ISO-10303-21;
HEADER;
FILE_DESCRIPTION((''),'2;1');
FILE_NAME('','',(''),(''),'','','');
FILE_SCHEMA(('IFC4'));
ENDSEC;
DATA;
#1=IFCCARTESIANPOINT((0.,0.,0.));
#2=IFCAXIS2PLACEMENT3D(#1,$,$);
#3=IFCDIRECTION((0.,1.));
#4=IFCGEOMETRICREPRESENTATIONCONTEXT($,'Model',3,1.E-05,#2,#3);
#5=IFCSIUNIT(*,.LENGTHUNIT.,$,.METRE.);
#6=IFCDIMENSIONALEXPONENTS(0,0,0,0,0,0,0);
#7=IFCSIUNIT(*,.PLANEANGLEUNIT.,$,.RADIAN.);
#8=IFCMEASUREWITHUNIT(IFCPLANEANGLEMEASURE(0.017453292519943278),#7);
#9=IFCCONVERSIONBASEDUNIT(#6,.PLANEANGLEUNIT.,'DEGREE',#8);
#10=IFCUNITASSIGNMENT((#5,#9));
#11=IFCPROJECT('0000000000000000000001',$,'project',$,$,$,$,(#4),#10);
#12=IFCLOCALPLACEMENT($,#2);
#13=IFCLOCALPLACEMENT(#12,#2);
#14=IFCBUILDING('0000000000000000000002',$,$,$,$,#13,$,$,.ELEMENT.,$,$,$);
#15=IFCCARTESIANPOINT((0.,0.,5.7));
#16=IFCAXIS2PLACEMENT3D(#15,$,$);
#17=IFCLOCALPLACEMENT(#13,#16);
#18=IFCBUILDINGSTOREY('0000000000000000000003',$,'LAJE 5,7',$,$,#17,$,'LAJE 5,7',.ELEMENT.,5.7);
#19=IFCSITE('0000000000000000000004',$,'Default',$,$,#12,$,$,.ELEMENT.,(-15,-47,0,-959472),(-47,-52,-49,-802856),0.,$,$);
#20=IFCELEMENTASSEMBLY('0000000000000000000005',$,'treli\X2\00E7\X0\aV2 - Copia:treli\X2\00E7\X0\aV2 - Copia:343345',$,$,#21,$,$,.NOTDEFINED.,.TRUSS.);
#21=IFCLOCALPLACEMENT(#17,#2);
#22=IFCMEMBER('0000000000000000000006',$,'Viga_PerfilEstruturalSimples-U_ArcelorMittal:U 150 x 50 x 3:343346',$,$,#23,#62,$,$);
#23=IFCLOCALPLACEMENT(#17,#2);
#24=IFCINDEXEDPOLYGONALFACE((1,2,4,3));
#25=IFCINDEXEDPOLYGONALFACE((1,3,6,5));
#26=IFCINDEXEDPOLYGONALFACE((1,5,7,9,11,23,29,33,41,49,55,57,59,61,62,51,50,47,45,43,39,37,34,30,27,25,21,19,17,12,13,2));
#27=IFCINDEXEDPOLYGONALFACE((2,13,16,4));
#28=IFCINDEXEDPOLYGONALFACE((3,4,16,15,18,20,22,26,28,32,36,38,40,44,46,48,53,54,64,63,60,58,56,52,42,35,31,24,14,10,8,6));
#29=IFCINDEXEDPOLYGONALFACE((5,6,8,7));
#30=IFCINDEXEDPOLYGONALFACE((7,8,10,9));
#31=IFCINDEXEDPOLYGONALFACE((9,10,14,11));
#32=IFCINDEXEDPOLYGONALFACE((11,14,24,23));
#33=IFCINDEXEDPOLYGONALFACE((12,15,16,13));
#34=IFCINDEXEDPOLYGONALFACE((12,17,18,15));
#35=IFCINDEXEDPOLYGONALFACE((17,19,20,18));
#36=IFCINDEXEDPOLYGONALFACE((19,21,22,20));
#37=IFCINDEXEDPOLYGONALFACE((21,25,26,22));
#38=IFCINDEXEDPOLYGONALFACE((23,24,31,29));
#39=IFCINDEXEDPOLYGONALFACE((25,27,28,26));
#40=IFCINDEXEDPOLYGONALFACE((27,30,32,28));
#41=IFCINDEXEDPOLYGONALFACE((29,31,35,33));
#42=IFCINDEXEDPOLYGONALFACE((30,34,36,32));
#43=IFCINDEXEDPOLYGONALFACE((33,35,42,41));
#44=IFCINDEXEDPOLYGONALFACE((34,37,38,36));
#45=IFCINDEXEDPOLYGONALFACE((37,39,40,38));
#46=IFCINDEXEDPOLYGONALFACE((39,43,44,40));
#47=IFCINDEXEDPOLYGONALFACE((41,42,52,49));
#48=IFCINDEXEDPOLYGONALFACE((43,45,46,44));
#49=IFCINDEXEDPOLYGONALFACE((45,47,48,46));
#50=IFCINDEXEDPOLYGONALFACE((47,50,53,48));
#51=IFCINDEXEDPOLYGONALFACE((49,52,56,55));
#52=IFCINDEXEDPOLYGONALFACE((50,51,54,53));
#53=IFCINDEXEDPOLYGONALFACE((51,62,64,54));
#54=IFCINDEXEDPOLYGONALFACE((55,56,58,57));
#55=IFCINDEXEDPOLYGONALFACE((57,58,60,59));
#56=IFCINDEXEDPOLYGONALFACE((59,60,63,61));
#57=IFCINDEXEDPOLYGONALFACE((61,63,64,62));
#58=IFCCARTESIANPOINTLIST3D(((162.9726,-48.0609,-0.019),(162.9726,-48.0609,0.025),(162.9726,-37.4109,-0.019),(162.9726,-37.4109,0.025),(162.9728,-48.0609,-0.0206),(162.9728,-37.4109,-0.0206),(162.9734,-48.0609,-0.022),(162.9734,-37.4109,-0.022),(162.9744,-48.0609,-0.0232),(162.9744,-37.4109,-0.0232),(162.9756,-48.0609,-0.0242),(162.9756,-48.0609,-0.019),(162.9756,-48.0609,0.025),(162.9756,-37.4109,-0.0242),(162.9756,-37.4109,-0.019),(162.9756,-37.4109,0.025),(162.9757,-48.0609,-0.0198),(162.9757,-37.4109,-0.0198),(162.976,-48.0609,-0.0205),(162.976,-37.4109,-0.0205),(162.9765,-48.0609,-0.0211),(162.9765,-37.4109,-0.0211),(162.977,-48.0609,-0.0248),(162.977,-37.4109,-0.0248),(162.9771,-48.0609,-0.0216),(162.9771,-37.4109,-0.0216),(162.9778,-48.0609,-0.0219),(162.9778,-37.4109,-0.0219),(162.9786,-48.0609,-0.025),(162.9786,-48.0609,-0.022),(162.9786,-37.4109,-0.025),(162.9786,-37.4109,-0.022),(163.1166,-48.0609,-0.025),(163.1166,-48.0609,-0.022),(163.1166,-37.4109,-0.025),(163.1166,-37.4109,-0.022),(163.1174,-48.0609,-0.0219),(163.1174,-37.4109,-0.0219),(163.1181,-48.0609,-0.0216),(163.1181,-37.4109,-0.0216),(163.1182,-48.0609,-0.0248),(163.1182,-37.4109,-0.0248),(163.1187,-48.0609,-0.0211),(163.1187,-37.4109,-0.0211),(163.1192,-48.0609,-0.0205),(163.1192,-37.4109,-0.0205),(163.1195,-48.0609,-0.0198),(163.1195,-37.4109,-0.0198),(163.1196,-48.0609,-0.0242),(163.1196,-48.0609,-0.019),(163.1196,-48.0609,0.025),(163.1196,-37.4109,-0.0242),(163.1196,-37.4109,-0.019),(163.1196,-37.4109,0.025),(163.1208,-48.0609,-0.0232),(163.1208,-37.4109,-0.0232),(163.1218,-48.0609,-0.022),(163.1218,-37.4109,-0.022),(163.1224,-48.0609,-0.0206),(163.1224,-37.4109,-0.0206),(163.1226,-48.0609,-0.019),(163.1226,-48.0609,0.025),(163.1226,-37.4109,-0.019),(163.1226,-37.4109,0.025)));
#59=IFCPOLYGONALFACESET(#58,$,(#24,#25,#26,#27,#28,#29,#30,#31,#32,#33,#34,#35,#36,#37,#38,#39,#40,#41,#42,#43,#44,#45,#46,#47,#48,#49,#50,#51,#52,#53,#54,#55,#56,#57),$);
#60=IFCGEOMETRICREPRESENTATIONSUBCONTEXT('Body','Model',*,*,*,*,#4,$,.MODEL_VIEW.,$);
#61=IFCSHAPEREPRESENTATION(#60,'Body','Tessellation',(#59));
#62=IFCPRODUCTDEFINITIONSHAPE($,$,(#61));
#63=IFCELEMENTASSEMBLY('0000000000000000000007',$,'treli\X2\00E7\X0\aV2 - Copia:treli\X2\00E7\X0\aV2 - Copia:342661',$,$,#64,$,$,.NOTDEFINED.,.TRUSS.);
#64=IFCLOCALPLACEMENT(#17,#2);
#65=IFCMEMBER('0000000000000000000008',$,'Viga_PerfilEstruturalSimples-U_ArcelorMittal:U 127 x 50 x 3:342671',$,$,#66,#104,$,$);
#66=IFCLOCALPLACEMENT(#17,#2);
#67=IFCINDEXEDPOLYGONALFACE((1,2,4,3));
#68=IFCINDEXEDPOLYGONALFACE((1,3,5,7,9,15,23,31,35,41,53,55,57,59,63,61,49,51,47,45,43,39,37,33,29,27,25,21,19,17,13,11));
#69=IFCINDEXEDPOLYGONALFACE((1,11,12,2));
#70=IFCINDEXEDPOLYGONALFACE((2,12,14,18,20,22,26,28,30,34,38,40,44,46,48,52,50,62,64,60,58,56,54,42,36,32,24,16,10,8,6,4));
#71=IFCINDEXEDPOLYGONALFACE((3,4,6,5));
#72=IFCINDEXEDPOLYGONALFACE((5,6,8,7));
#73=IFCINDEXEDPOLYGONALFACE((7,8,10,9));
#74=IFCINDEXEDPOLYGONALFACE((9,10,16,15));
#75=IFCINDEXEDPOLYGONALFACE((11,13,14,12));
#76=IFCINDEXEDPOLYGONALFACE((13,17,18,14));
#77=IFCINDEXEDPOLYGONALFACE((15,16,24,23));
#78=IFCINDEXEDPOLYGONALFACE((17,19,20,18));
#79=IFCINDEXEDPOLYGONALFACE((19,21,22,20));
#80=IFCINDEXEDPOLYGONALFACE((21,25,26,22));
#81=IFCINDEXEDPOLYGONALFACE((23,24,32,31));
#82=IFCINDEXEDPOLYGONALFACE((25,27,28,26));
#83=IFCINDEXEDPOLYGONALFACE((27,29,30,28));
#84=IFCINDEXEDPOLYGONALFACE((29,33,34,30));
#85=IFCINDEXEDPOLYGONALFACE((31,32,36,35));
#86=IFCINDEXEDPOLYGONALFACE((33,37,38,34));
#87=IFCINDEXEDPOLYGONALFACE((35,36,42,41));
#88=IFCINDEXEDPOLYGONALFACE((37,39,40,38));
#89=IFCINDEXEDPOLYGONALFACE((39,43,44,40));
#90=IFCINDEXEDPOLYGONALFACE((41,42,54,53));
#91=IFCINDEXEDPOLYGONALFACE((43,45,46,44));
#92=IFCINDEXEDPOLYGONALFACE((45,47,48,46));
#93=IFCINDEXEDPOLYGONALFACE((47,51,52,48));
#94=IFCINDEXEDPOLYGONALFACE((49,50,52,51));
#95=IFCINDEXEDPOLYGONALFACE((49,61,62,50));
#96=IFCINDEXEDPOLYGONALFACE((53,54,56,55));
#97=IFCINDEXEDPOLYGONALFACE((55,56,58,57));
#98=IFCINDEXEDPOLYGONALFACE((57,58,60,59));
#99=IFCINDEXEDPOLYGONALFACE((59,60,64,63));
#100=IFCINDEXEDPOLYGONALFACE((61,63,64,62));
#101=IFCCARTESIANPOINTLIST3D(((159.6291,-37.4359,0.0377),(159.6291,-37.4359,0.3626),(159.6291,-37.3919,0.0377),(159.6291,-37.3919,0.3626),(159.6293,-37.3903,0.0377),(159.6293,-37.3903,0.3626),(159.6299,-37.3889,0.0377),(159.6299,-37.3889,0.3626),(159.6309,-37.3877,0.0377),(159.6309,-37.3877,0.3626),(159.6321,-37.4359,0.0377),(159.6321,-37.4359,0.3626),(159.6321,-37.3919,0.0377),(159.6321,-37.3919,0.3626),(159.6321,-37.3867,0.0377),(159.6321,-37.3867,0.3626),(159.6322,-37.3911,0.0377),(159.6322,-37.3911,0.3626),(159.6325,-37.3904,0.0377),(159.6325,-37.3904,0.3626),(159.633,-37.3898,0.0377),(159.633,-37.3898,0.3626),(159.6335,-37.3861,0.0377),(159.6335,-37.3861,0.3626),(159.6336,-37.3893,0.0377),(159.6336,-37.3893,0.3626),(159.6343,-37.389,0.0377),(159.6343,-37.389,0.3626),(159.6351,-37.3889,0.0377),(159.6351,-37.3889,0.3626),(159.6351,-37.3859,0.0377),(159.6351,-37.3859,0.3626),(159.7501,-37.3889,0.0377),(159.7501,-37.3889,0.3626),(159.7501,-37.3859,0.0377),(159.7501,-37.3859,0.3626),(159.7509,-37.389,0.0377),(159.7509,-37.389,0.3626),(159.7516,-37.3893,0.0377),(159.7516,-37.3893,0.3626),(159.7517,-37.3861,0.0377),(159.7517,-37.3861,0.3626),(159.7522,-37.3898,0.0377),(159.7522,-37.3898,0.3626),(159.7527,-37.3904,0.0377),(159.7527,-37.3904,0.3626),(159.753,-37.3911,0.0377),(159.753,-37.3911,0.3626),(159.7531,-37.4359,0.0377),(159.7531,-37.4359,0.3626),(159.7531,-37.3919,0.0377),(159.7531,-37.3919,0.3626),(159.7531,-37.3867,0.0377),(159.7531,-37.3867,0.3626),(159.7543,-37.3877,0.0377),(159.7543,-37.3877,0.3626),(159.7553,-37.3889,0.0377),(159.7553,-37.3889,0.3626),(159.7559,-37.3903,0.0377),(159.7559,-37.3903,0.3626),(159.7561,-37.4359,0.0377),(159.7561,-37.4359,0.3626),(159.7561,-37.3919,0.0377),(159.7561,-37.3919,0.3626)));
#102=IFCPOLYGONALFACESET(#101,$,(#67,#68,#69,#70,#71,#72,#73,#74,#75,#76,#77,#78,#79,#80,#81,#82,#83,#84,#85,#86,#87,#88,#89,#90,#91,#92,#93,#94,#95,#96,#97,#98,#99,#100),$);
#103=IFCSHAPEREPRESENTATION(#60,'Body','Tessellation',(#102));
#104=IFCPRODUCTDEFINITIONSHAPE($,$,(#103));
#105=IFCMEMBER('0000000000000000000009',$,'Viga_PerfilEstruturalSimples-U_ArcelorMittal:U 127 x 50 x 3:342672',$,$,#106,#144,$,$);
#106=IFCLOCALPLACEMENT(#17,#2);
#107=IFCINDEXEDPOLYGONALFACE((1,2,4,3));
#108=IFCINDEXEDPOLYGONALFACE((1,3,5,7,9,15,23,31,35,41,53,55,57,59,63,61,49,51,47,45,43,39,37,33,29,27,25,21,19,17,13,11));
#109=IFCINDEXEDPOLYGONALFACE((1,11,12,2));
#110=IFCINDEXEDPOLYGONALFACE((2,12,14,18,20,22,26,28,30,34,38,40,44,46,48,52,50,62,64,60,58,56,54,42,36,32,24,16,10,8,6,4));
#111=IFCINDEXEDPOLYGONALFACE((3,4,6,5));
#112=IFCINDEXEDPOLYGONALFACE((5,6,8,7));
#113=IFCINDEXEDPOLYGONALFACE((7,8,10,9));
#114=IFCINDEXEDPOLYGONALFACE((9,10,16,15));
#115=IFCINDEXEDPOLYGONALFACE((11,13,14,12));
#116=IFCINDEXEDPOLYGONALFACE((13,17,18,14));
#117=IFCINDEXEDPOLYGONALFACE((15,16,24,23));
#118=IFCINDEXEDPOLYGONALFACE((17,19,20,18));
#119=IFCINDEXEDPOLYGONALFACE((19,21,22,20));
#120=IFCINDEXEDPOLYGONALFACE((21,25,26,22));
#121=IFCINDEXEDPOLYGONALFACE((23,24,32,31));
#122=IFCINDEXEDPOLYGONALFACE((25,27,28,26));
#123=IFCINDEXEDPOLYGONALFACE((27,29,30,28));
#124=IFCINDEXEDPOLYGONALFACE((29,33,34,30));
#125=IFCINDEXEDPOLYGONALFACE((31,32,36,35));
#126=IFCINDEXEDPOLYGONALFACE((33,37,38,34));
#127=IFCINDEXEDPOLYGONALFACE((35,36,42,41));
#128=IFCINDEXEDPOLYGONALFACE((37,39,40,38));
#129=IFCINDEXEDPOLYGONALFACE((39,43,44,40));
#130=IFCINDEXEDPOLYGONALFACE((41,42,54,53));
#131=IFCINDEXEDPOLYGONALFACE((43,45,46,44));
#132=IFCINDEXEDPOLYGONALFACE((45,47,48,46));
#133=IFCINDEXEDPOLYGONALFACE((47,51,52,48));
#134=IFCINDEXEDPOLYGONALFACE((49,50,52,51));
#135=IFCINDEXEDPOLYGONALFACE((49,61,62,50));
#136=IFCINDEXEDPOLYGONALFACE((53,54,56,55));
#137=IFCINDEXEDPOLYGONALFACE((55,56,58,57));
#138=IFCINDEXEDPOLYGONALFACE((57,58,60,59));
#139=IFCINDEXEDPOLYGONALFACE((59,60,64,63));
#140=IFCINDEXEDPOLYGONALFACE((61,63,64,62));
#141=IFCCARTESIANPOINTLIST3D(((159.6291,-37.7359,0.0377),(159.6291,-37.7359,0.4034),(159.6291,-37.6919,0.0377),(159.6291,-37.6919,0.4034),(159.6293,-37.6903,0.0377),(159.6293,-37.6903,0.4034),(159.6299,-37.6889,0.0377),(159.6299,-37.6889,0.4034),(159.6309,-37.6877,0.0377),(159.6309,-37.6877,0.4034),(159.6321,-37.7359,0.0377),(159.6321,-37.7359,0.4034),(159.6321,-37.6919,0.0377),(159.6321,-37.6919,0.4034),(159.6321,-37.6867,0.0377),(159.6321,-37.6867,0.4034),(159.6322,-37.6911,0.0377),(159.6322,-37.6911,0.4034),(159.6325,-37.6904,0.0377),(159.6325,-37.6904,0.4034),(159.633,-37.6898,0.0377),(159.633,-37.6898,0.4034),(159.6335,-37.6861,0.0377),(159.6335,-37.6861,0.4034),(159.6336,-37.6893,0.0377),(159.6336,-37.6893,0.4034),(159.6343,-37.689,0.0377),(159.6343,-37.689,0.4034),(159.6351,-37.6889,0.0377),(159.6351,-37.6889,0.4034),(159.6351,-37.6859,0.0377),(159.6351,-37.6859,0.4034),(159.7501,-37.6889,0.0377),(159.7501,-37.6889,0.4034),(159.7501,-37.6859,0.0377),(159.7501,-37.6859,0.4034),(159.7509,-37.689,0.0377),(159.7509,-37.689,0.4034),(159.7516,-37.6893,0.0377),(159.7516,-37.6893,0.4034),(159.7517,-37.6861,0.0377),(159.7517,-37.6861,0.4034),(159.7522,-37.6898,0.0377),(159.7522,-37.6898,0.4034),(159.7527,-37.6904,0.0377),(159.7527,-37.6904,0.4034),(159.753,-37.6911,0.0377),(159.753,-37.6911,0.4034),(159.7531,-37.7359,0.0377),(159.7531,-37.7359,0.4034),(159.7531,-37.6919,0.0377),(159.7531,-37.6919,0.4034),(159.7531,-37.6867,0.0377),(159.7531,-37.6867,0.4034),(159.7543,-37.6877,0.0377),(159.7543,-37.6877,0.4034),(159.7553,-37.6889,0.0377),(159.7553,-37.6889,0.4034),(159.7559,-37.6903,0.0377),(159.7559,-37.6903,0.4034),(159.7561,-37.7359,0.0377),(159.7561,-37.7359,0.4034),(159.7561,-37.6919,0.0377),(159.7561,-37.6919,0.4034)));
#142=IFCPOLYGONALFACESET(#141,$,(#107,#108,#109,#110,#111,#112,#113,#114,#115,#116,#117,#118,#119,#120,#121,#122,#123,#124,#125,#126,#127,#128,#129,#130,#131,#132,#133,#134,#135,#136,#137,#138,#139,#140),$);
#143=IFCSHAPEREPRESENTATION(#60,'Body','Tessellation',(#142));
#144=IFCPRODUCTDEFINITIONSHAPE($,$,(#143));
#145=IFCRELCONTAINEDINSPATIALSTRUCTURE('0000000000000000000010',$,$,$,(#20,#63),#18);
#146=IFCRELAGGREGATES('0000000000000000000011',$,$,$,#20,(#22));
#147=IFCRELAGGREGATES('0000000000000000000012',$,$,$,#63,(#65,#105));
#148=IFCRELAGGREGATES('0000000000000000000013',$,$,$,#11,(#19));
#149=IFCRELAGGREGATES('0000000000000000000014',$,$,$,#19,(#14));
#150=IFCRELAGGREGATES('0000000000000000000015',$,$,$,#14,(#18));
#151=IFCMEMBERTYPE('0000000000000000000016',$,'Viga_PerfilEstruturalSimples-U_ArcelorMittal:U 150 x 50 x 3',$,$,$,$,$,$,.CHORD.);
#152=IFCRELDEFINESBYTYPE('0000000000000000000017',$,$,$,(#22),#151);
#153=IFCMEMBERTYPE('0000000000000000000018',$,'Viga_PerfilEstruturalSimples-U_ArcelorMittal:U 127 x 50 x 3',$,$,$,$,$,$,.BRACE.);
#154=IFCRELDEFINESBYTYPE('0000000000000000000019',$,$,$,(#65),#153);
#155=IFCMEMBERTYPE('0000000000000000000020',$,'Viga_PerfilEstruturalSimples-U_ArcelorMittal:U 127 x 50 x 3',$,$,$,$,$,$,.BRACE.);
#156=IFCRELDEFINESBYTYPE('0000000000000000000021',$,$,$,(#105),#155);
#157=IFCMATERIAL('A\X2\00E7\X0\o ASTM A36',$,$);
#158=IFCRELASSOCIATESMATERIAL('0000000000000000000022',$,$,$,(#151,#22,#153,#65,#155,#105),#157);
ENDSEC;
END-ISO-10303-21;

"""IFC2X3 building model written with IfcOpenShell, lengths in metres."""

from ifc_helpers import new_model, entity, si_unit, converted_unit, direction, frame, frame_2d, origin, place, context, subcontext, project, spatial, polyline, circle_curve, parameter, trimmed, segment, composite_curve, outline, extrude, source, transform, mapped, material, type_object, type_shapes, element, aggregate, save


model = new_model("IFC2X3")

# Units and contexts
model_context = context("Model", 3, precision=1e-05, world=origin(), true_north=direction((0.0, 1.0)))
body_context = subcontext(model_context, "Body", "Model", "MODEL_VIEW")
ifc_project = project(units=[si_unit("LENGTHUNIT", "METRE"), converted_unit("PLANEANGLEUNIT", "DEGREE", entity("IfcPlaneAngleMeasure", 0.017453292519943278), si_unit("PLANEANGLEUNIT", "RADIAN"), dimensions=[0, 0, 0, 0, 0, 0, 0])], contexts=[model_context])

# Site, building, storey
site_placement = place(None, origin())
site = spatial("IfcSite", under=ifc_project, at=site_placement, Name="Default", CompositionType="ELEMENT", RefLatitude=(-15, -47, 0, -959472), RefLongitude=(-47, -52, -49, -802856), RefElevation=0.0)
building_placement = place(site_placement, origin())
building = spatial("IfcBuilding", under=site, at=building_placement, CompositionType="ELEMENT")
storey_placement = place(building_placement, frame((0.0, 0.0, 5.7)))
storey = spatial("IfcBuildingStorey", under=building, at=storey_placement, Name="LAJE 5,7", LongName="LAJE 5,7", CompositionType="ELEMENT", Elevation=5.7)

# Element assemblies, members
assembly_1_placement = place(storey_placement, origin())
assembly_1 = element("IfcElementAssembly", 1, at=assembly_1_placement, inside=storey, Name="treliçaV2 - Copia:treliçaV2 - Copia:343345", AssemblyPlace="NOTDEFINED", PredefinedType="TRUSS")
ifc_material = material(Name="Aço ASTM A36")
member_type_1 = type_object("IfcMemberType", Name="Viga_PerfilEstruturalSimples-U_ArcelorMittal:U 150 x 50 x 3", PredefinedType="CHORD", material=ifc_material)
shared_shape_1 = source(origin(), body_context, "Body", "SweptSolid", [
    extrude(outline(composite_curve([segment(polyline([(-0.069, -0.0192), (0.069, -0.0192)]), True, "CONTINUOUS"), segment(trimmed(circle_curve(frame_2d((0.069, -0.0132), x_axis=(0.0, 1.0)), 0.006), [parameter(180.0)], [parameter(270.0)], True, "PARAMETER"), True, "CONTINUOUS"), segment(polyline([(0.075, -0.0132), (0.075, 0.0308)]), True, "CONTINUOUS"), segment(polyline([(0.075, 0.0308), (0.072, 0.0308)]), True, "CONTINUOUS"), segment(polyline([(0.072, 0.0308), (0.072, -0.0132)]), True, "CONTINUOUS"), segment(trimmed(circle_curve(frame_2d((0.069, -0.0132), x_axis=(0.0, 1.0)), 0.003), [parameter(180.0)], [parameter(270.0)], True, "PARAMETER"), False, "CONTINUOUS"), segment(polyline([(0.069, -0.0162), (-0.069, -0.0162)]), True, "CONTINUOUS"), segment(trimmed(circle_curve(frame_2d((-0.069, -0.0132), x_axis=(0.0, 1.0)), 0.003), [parameter(90.0)], [parameter(180.0)], True, "PARAMETER"), False, "CONTINUOUS"), segment(polyline([(-0.072, -0.0132), (-0.072, 0.0308)]), True, "CONTINUOUS"), segment(polyline([(-0.072, 0.0308), (-0.075, 0.0308)]), True, "CONTINUOUS"), segment(polyline([(-0.075, 0.0308), (-0.075, -0.0132)]), True, "CONTINUOUS"), segment(trimmed(circle_curve(frame_2d((-0.069, -0.0132), x_axis=(0.0, 1.0)), 0.006), [parameter(90.0)], [parameter(180.0)], True, "PARAMETER"), True, "CONTINUOUS")], self_intersect=False)), frame((-5.325, -0.0058, 0.0), z_axis=(1.0, 0.0, 0.0), x_axis=(0.0, 0.0, -1.0)), (0.0, 0.0, 1.0), 10.65),
])
type_shapes(member_type_1, [shared_shape_1])
member_1_placement = place(assembly_1_placement, frame((163.0476, -42.7359, 0.0), z_axis=(1.0, 0.0, 0.0), x_axis=(0.0, 1.0, 0.0)))
member_1 = element("IfcMember", 2, at=member_1_placement, type_object=member_type_1, material=ifc_material, Name="Viga_PerfilEstruturalSimples-U_ArcelorMittal:U 150 x 50 x 3:343346", context=body_context, shape_type="MappedRepresentation", body=[
    mapped(shared_shape_1, transform((0.0, 0.0, 0.0), scale=1.0)),
])
assembly_2_placement = place(storey_placement, origin())
assembly_2 = element("IfcElementAssembly", 3, at=assembly_2_placement, inside=storey, Name="treliçaV2 - Copia:treliçaV2 - Copia:342661", AssemblyPlace="NOTDEFINED", PredefinedType="TRUSS")
member_type_2 = type_object("IfcMemberType", Name="Viga_PerfilEstruturalSimples-U_ArcelorMittal:U 127 x 50 x 3", PredefinedType="BRACE", material=ifc_material)
shared_shape_2 = source(origin(), body_context, "Body", "SweptSolid", [
    extrude(outline(composite_curve([segment(polyline([(-0.0575, -0.0192), (0.0575, -0.0192)]), True, "CONTINUOUS"), segment(trimmed(circle_curve(frame_2d((0.0575, -0.0132), x_axis=(0.0, 1.0)), 0.006), [parameter(180.0)], [parameter(270.0)], True, "PARAMETER"), True, "CONTINUOUS"), segment(polyline([(0.0635, -0.0132), (0.0635, 0.0308)]), True, "CONTINUOUS"), segment(polyline([(0.0635, 0.0308), (0.0605, 0.0308)]), True, "CONTINUOUS"), segment(polyline([(0.0605, 0.0308), (0.0605, -0.0132)]), True, "CONTINUOUS"), segment(trimmed(circle_curve(frame_2d((0.0575, -0.0132), x_axis=(0.0, 1.0)), 0.003), [parameter(180.0)], [parameter(270.0)], True, "PARAMETER"), False, "CONTINUOUS"), segment(polyline([(0.0575, -0.0162), (-0.0575, -0.0162)]), True, "CONTINUOUS"), segment(trimmed(circle_curve(frame_2d((-0.0575, -0.0132), x_axis=(0.0, 1.0)), 0.003), [parameter(90.0)], [parameter(180.0)], True, "PARAMETER"), False, "CONTINUOUS"), segment(polyline([(-0.0605, -0.0132), (-0.0605, 0.0308)]), True, "CONTINUOUS"), segment(polyline([(-0.0605, 0.0308), (-0.0635, 0.0308)]), True, "CONTINUOUS"), segment(polyline([(-0.0635, 0.0308), (-0.0635, -0.0132)]), True, "CONTINUOUS"), segment(trimmed(circle_curve(frame_2d((-0.0575, -0.0132), x_axis=(0.0, 1.0)), 0.006), [parameter(90.0)], [parameter(180.0)], True, "PARAMETER"), True, "CONTINUOUS")], self_intersect=False)), frame((-0.1623, -0.0058, 0.0), z_axis=(1.0, 0.0, 0.0), x_axis=(0.0, 0.0, -1.0)), (0.0, 0.0, 1.0), 0.3249),
])
type_shapes(member_type_2, [shared_shape_2])
member_2_placement = place(assembly_2_placement, frame((159.6926, -37.4109, 0.2), z_axis=(1.0, 0.0, 0.0), x_axis=(0.0, 0.0, 1.0)))
member_2 = element("IfcMember", 4, at=member_2_placement, type_object=member_type_2, material=ifc_material, Name="Viga_PerfilEstruturalSimples-U_ArcelorMittal:U 127 x 50 x 3:342671", context=body_context, shape_type="MappedRepresentation", body=[
    mapped(shared_shape_2, transform((0.0, 0.0, 0.0), scale=1.0)),
])

# Member
member_type_3 = type_object("IfcMemberType", Name="Viga_PerfilEstruturalSimples-U_ArcelorMittal:U 127 x 50 x 3", PredefinedType="BRACE", material=ifc_material)
shared_shape_3 = source(origin(), body_context, "Body", "SweptSolid", [
    extrude(outline(composite_curve([segment(polyline([(-0.0575, -0.0192), (0.0575, -0.0192)]), True, "CONTINUOUS"), segment(trimmed(circle_curve(frame_2d((0.0575, -0.0132), x_axis=(0.0, 1.0)), 0.006), [parameter(180.0)], [parameter(270.0)], True, "PARAMETER"), True, "CONTINUOUS"), segment(polyline([(0.0635, -0.0132), (0.0635, 0.0308)]), True, "CONTINUOUS"), segment(polyline([(0.0635, 0.0308), (0.0605, 0.0308)]), True, "CONTINUOUS"), segment(polyline([(0.0605, 0.0308), (0.0605, -0.0132)]), True, "CONTINUOUS"), segment(trimmed(circle_curve(frame_2d((0.0575, -0.0132), x_axis=(0.0, 1.0)), 0.003), [parameter(180.0)], [parameter(270.0)], True, "PARAMETER"), False, "CONTINUOUS"), segment(polyline([(0.0575, -0.0162), (-0.0575, -0.0162)]), True, "CONTINUOUS"), segment(trimmed(circle_curve(frame_2d((-0.0575, -0.0132), x_axis=(0.0, 1.0)), 0.003), [parameter(90.0)], [parameter(180.0)], True, "PARAMETER"), False, "CONTINUOUS"), segment(polyline([(-0.0605, -0.0132), (-0.0605, 0.0308)]), True, "CONTINUOUS"), segment(polyline([(-0.0605, 0.0308), (-0.0635, 0.0308)]), True, "CONTINUOUS"), segment(polyline([(-0.0635, 0.0308), (-0.0635, -0.0132)]), True, "CONTINUOUS"), segment(trimmed(circle_curve(frame_2d((-0.0575, -0.0132), x_axis=(0.0, 1.0)), 0.006), [parameter(90.0)], [parameter(180.0)], True, "PARAMETER"), True, "CONTINUOUS")], self_intersect=False)), frame((-0.1849, -0.0058, 0.0), z_axis=(1.0, 0.0, 0.0), x_axis=(0.0, 0.0, -1.0)), (0.0, 0.0, 1.0), 0.3657),
])
type_shapes(member_type_3, [shared_shape_3])
member_3_placement = place(assembly_2_placement, frame((159.6926, -37.7109, 0.2226), z_axis=(1.0, 0.0, 0.0), x_axis=(0.0, 0.0, 1.0)))
member_3 = element("IfcMember", 5, at=member_3_placement, type_object=member_type_3, material=ifc_material, Name="Viga_PerfilEstruturalSimples-U_ArcelorMittal:U 127 x 50 x 3:342672", context=body_context, shape_type="MappedRepresentation", body=[
    mapped(shared_shape_3, transform((0.0, 0.0, 0.0), scale=1.0)),
])
aggregate(assembly_1, [member_1])
aggregate(assembly_2, [member_2, member_3])

save(model, "model.ifc")
